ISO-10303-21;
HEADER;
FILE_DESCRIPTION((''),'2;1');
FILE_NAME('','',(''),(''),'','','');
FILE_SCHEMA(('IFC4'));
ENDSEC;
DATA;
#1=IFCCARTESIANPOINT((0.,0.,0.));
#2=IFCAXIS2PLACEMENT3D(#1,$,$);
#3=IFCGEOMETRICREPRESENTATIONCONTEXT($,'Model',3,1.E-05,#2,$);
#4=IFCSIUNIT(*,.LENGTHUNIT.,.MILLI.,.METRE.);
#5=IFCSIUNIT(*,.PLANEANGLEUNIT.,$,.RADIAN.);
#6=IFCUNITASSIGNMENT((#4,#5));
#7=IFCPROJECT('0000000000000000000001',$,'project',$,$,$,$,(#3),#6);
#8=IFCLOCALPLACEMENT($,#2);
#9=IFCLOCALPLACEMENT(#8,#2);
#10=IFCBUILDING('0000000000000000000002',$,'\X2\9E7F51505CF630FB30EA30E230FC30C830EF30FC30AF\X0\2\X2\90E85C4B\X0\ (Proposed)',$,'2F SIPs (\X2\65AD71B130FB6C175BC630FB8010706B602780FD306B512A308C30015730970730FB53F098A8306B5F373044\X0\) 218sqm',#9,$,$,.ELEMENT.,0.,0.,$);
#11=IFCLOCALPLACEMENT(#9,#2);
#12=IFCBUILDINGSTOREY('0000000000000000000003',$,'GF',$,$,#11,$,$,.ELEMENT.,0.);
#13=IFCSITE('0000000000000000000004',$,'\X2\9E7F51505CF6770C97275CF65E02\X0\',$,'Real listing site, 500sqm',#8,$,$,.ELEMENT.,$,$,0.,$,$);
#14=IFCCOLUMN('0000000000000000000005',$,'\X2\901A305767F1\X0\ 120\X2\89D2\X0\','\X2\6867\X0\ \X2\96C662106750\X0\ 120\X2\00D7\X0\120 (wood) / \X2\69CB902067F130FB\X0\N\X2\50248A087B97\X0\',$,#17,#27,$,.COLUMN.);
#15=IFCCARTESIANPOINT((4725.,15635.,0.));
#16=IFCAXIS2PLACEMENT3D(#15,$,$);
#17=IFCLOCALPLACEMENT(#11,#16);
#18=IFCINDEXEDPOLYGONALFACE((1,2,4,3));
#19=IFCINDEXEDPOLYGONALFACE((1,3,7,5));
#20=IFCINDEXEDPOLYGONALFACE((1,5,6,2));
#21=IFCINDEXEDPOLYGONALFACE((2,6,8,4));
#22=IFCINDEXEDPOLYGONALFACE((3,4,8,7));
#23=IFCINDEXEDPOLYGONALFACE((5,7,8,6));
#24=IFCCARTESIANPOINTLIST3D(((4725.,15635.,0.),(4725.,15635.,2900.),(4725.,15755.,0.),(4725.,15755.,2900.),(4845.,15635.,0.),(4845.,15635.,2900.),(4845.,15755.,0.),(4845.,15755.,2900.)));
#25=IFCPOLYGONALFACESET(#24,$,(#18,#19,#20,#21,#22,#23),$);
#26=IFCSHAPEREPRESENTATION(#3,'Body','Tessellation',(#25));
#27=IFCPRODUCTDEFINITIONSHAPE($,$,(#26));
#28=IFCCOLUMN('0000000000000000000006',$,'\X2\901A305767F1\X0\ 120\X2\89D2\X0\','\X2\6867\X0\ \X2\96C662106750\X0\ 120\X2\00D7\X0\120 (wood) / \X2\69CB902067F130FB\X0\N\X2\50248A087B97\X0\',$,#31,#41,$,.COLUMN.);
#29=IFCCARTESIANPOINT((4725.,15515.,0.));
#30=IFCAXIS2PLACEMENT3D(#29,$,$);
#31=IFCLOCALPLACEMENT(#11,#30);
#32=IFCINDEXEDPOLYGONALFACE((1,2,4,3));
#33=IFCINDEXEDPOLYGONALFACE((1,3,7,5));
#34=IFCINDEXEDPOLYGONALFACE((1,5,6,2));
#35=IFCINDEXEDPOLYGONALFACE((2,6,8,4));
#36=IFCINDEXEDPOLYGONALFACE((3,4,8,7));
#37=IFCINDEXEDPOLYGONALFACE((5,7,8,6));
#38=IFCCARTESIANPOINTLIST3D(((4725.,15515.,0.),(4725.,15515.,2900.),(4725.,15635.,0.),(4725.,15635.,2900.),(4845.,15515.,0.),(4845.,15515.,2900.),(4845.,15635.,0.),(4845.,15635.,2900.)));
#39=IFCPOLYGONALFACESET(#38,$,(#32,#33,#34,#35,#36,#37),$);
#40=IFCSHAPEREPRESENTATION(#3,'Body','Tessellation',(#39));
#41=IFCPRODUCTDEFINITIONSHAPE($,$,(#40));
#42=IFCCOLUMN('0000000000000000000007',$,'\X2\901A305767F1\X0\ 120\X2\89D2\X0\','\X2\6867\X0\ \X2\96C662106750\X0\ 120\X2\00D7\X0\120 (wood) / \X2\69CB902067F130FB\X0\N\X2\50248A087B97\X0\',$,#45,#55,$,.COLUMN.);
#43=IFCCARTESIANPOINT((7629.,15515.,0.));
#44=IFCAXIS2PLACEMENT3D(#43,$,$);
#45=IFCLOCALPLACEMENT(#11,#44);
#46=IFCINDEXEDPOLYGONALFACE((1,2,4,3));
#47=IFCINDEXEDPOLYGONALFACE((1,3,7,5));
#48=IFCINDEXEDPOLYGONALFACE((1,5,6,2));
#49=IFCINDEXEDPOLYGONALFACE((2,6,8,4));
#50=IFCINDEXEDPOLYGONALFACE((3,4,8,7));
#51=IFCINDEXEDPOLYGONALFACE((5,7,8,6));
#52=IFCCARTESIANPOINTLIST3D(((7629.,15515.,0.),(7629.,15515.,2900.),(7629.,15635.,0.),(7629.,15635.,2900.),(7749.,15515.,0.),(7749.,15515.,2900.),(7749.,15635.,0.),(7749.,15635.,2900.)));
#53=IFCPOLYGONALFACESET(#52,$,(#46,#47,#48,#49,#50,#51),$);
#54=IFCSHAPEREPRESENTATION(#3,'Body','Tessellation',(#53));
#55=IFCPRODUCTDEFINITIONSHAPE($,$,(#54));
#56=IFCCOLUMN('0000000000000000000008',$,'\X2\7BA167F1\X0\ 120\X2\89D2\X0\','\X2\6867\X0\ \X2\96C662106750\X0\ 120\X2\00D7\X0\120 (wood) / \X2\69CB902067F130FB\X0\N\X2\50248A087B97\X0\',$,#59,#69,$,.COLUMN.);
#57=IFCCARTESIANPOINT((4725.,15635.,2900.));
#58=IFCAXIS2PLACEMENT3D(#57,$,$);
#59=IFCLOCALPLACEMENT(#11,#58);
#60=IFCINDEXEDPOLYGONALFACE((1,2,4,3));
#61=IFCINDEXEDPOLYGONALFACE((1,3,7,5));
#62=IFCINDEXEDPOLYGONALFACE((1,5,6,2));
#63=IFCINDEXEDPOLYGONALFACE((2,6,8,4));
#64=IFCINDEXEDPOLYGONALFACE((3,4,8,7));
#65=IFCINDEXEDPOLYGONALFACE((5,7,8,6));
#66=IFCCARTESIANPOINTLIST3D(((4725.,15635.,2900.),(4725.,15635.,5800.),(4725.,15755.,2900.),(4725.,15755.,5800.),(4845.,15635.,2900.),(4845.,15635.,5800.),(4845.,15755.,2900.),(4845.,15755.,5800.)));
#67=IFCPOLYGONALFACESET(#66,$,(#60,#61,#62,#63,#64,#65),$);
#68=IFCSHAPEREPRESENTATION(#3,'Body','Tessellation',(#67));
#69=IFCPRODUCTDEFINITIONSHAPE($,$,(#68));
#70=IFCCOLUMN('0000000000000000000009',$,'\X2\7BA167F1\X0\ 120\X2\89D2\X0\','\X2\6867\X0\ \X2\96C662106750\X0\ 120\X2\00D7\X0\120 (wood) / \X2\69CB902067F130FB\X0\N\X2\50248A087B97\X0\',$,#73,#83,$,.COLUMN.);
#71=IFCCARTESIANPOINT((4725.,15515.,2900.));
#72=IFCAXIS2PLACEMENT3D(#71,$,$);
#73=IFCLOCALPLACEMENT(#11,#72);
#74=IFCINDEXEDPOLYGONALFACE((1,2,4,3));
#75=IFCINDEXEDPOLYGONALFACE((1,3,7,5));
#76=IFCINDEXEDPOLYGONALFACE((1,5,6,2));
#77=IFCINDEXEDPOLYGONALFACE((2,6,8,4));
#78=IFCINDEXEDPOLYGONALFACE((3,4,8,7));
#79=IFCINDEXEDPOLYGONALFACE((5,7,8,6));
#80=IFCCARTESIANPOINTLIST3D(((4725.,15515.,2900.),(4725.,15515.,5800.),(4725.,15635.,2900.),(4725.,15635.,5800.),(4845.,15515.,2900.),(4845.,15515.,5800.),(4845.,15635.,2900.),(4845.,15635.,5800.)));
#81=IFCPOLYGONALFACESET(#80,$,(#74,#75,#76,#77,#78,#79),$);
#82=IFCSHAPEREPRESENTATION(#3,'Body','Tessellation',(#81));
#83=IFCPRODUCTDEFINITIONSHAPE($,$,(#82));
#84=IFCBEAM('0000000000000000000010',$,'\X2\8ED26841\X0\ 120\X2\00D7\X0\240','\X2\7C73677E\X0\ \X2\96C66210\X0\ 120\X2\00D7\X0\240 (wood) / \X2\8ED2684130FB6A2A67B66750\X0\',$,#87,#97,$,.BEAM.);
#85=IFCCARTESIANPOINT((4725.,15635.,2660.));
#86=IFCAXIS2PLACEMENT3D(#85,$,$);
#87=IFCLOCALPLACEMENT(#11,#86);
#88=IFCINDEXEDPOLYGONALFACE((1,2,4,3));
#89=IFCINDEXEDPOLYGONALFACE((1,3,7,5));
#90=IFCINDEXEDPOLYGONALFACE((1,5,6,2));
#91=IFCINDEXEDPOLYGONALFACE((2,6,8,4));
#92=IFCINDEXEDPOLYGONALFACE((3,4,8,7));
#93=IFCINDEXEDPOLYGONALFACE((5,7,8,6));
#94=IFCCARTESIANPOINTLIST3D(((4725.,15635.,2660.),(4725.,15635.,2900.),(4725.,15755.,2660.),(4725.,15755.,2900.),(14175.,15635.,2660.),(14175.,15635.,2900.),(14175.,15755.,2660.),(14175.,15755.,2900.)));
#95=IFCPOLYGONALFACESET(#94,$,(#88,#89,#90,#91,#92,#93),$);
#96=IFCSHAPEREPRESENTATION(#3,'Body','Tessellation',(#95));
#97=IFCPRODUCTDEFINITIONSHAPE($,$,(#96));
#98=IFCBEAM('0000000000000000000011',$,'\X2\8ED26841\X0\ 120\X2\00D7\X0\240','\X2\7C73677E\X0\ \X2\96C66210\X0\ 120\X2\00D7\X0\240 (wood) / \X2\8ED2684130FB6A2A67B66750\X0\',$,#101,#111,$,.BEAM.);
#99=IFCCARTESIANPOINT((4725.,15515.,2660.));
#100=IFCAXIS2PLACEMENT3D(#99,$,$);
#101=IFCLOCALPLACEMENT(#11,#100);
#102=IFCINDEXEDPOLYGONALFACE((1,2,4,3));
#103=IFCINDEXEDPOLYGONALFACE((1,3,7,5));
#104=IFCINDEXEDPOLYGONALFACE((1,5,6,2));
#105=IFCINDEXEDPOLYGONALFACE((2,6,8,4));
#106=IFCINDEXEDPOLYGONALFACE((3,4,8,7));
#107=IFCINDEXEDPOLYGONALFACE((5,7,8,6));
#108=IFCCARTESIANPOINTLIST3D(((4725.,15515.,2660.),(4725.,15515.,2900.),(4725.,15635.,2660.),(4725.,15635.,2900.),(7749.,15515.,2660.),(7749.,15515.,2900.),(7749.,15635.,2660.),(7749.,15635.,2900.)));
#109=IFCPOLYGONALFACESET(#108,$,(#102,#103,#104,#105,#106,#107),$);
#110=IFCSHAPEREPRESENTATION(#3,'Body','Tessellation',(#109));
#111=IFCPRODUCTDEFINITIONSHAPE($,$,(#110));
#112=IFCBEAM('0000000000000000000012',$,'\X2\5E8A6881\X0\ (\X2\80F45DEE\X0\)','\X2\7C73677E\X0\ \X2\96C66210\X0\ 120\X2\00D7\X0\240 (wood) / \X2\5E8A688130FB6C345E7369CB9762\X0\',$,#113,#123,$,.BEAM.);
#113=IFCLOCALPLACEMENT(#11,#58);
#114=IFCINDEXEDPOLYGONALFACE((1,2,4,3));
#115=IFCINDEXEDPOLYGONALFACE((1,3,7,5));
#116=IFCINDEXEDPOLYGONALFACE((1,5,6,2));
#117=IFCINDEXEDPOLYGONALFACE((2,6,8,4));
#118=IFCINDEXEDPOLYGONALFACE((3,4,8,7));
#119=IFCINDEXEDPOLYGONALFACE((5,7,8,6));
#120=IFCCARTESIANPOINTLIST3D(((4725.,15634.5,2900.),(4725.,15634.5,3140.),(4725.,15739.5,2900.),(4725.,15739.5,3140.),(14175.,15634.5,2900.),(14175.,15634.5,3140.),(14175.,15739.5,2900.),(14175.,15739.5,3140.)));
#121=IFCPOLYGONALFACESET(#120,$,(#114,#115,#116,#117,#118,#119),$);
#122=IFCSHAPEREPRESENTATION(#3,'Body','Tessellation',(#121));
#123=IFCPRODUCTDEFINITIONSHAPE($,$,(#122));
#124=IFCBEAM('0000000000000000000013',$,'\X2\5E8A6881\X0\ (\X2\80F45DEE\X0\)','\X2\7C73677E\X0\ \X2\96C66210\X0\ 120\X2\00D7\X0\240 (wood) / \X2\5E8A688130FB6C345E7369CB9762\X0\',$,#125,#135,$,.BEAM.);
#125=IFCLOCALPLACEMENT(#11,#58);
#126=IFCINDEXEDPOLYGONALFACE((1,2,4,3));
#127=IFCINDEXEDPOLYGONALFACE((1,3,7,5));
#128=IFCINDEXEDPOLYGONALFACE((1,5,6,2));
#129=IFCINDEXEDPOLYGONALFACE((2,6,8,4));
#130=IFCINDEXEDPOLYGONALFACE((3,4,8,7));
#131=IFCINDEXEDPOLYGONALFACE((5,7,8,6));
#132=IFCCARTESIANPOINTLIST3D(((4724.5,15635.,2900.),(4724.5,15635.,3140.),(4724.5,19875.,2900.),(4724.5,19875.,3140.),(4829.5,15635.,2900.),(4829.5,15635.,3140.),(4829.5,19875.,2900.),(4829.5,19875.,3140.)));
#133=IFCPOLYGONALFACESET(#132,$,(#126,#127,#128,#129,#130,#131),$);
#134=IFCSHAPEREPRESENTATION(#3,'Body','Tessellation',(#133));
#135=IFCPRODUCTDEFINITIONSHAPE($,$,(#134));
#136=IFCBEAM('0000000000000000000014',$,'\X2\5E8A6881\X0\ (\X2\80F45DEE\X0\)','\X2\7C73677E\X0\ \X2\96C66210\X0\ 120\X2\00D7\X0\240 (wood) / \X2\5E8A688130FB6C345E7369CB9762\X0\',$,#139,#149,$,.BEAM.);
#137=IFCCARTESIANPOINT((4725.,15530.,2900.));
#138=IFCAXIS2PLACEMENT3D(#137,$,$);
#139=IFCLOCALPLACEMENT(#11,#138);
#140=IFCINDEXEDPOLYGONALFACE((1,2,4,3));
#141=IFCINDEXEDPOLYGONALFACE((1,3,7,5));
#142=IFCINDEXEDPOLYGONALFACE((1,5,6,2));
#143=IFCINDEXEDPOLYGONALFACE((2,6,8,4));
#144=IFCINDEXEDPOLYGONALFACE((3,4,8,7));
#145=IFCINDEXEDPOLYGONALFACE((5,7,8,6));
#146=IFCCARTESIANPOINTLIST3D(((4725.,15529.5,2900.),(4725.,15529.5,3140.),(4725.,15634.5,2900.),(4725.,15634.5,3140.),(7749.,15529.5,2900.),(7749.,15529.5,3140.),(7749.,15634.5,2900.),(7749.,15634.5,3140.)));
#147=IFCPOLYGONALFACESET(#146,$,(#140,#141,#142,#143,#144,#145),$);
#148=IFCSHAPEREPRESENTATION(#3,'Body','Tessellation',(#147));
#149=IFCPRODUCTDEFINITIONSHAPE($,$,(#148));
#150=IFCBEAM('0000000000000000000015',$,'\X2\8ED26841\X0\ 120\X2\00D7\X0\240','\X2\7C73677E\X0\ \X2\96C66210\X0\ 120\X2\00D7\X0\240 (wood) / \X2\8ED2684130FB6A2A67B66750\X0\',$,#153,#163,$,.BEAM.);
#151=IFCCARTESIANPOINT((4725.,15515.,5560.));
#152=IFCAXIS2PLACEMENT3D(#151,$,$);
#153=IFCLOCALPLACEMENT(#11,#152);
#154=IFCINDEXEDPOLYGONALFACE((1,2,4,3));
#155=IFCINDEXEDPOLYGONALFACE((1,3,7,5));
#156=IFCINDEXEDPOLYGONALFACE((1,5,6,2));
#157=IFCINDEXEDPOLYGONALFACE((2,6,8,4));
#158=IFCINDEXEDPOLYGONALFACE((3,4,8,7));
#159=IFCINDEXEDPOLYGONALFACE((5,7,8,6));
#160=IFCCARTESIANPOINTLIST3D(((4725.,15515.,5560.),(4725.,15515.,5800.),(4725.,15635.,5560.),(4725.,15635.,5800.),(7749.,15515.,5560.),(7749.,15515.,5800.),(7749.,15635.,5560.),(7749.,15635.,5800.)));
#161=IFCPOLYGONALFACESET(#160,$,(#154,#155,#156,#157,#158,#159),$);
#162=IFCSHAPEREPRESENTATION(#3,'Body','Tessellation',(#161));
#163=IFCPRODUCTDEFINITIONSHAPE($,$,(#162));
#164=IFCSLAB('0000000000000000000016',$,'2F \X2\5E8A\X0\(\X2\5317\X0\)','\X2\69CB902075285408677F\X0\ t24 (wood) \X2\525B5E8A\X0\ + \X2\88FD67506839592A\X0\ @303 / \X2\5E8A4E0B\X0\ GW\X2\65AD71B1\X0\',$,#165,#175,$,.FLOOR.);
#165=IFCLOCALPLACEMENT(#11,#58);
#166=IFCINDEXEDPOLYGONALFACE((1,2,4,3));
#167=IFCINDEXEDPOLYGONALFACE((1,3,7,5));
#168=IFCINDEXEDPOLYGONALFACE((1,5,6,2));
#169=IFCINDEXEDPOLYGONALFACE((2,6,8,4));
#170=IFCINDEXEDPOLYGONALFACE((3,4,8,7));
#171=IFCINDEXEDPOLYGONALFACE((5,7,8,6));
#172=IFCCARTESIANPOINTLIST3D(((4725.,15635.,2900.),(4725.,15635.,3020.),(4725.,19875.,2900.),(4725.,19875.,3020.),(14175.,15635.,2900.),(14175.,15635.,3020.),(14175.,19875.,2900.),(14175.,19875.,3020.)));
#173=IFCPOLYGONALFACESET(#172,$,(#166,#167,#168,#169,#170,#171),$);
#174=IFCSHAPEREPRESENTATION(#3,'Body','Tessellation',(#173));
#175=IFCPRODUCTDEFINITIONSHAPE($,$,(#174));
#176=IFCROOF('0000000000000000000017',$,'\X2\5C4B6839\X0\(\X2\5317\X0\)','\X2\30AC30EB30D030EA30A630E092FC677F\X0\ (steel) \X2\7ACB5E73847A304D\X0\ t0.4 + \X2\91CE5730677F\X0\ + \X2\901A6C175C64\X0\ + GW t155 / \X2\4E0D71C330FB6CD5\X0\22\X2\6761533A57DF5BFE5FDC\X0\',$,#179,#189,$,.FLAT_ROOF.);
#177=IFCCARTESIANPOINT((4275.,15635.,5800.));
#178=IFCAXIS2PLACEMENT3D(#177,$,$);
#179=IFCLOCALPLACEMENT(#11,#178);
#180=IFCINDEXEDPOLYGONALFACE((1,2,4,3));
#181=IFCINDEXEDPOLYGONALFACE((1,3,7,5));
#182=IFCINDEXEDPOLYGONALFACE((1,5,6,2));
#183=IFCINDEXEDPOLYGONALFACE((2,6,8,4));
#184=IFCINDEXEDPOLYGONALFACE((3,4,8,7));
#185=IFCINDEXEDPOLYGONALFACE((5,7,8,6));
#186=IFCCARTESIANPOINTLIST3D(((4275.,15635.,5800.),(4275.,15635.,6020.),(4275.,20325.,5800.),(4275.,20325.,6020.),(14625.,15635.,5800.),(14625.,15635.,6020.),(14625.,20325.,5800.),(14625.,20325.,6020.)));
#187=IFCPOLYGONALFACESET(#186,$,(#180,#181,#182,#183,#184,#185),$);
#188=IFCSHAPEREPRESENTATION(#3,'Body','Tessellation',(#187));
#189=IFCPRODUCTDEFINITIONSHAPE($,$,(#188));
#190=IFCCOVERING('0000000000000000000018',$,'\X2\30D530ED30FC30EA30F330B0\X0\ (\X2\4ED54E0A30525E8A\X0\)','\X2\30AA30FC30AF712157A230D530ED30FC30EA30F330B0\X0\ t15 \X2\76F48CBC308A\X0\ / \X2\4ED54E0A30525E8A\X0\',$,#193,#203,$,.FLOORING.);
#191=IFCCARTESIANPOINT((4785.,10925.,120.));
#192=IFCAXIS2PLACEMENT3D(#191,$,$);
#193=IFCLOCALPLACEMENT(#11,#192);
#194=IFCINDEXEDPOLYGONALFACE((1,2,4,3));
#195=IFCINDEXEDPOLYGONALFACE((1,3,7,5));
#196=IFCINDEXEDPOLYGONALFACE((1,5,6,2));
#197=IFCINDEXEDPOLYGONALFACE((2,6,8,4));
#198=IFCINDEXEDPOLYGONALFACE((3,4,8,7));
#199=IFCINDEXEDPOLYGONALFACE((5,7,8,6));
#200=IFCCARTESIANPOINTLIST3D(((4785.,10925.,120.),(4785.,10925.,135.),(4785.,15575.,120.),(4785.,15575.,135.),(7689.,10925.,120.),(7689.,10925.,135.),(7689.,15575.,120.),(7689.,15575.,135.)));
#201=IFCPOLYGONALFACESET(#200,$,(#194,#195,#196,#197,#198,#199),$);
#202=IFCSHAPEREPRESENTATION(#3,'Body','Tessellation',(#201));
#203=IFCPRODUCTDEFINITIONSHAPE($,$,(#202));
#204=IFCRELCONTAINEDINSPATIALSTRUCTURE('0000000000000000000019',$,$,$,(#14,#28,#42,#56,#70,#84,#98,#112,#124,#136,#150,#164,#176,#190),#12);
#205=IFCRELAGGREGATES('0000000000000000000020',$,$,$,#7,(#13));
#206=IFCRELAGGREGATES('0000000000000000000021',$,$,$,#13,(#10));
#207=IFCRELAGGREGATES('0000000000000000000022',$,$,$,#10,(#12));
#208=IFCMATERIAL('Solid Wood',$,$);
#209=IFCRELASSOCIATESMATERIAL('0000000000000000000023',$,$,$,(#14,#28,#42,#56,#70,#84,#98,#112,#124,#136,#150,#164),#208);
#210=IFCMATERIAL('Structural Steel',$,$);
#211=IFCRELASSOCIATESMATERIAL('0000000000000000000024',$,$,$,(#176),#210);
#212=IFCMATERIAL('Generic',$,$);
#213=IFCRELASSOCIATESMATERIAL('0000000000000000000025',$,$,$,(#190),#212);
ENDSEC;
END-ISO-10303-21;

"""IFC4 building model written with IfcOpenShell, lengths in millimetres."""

from ifc_helpers import new_model, si_unit, frame, frame_2d, origin, place, context, project, spatial, rectangle, extrude, material, element, save


model = new_model("IFC4")

# Units and contexts
model_context = context("Model", 3, precision=1e-05, world=origin())
ifc_project = project(units=[si_unit("LENGTHUNIT", "METRE", prefix="MILLI"), si_unit("PLANEANGLEUNIT", "RADIAN")], contexts=[model_context])

# Site, building, storey
site_placement = place(None, origin())
site = spatial("IfcSite", under=ifc_project, at=site_placement, Name="鹿児島県霧島市", ObjectType="Real listing site, 500sqm", CompositionType="ELEMENT", RefElevation=0.0)
building_placement = place(site_placement, origin())
building = spatial("IfcBuilding", under=site, at=building_placement, Name="鹿児島・リモートワーク2部屋 (Proposed)", ObjectType="2F SIPs (断熱・気密・耐火性能に優れ、地震・台風に強い) 218sqm", CompositionType="ELEMENT", ElevationOfRefHeight=0.0, ElevationOfTerrain=0.0)
storey_placement = place(building_placement, origin())
storey = spatial("IfcBuildingStorey", under=building, at=storey_placement, Name="GF", CompositionType="ELEMENT", Elevation=0.0)

# Columns
ifc_material_1 = material(Name="Solid Wood")
column_1_placement = place(storey_placement, frame((4725.0, 15635.0, 0.0)))
element("IfcColumn", 1, at=column_1_placement, inside=storey, material=ifc_material_1, Name="通し柱 120角", Description="桧 集成材 120×120 (wood) / 構造柱・N値計算", PredefinedType="COLUMN", context=model_context, shape_type="SweptSolid", body=[
    extrude(rectangle(XDim=120.0, YDim=120.0, at=frame_2d((60.0, 60.0))), frame((4725.0, 15635.0, 0.0)), (0.0, 0.0, 1.0), 2900.0),
])
column_2_placement = place(storey_placement, frame((4725.0, 15515.0, 0.0)))
element("IfcColumn", 2, at=column_2_placement, inside=storey, material=ifc_material_1, Name="通し柱 120角", Description="桧 集成材 120×120 (wood) / 構造柱・N値計算", PredefinedType="COLUMN", context=model_context, shape_type="SweptSolid", body=[
    extrude(rectangle(XDim=120.0, YDim=120.0, at=frame_2d((60.0, 60.0))), frame((4725.0, 15515.0, 0.0)), (0.0, 0.0, 1.0), 2900.0),
])
column_3_placement = place(storey_placement, frame((7629.0, 15515.0, 0.0)))
element("IfcColumn", 3, at=column_3_placement, inside=storey, material=ifc_material_1, Name="通し柱 120角", Description="桧 集成材 120×120 (wood) / 構造柱・N値計算", PredefinedType="COLUMN", context=model_context, shape_type="SweptSolid", body=[
    extrude(rectangle(XDim=120.0, YDim=120.0, at=frame_2d((60.0, 60.0))), frame((7629.0, 15515.0, 0.0)), (0.0, 0.0, 1.0), 2900.0),
])
column_4_placement = place(storey_placement, frame((4725.0, 15635.0, 2900.0)))
element("IfcColumn", 4, at=column_4_placement, inside=storey, material=ifc_material_1, Name="管柱 120角", Description="桧 集成材 120×120 (wood) / 構造柱・N値計算", PredefinedType="COLUMN", context=model_context, shape_type="SweptSolid", body=[
    extrude(rectangle(XDim=120.0, YDim=120.0, at=frame_2d((60.0, 60.0))), frame((4725.0, 15635.0, 2900.0)), (0.0, 0.0, 1.0), 2900.0),
])
column_5_placement = place(storey_placement, frame((4725.0, 15515.0, 2900.0)))
element("IfcColumn", 5, at=column_5_placement, inside=storey, material=ifc_material_1, Name="管柱 120角", Description="桧 集成材 120×120 (wood) / 構造柱・N値計算", PredefinedType="COLUMN", context=model_context, shape_type="SweptSolid", body=[
    extrude(rectangle(XDim=120.0, YDim=120.0, at=frame_2d((60.0, 60.0))), frame((4725.0, 15515.0, 2900.0)), (0.0, 0.0, 1.0), 2900.0),
])

# Beams
beam_1_placement = place(storey_placement, frame((4725.0, 15635.0, 2660.0)))
element("IfcBeam", 6, at=beam_1_placement, inside=storey, material=ifc_material_1, Name="軒桁 120×240", Description="米松 集成 120×240 (wood) / 軒桁・横架材", PredefinedType="BEAM", context=model_context, shape_type="SweptSolid", body=[
    extrude(rectangle(XDim=9450.0, YDim=120.0, at=frame_2d((4725.0, 60.0))), frame((4725.0, 15635.0, 2660.0)), (0.0, 0.0, 1.0), 240.0),
])
beam_2_placement = place(storey_placement, frame((4725.0, 15515.0, 2660.0)))
element("IfcBeam", 7, at=beam_2_placement, inside=storey, material=ifc_material_1, Name="軒桁 120×240", Description="米松 集成 120×240 (wood) / 軒桁・横架材", PredefinedType="BEAM", context=model_context, shape_type="SweptSolid", body=[
    extrude(rectangle(XDim=3024.0, YDim=120.0, at=frame_2d((1512.0, 60.0))), frame((4725.0, 15515.0, 2660.0)), (0.0, 0.0, 1.0), 240.0),
])
beam_3_placement = place(storey_placement, frame((4725.0, 15635.0, 2900.0)))
element("IfcBeam", 8, at=beam_3_placement, inside=storey, material=ifc_material_1, Name="床梁 (胴差)", Description="米松 集成 120×240 (wood) / 床梁・水平構面", PredefinedType="BEAM", context=model_context, shape_type="SweptSolid", body=[
    extrude(rectangle(XDim=9450.0, YDim=105.0, at=frame_2d((4725.0, 52.0))), frame((4725.0, 15635.0, 2900.0)), (0.0, 0.0, 1.0), 240.0),
])
beam_4_placement = place(storey_placement, frame((4725.0, 15635.0, 2900.0)))
element("IfcBeam", 9, at=beam_4_placement, inside=storey, material=ifc_material_1, Name="床梁 (胴差)", Description="米松 集成 120×240 (wood) / 床梁・水平構面", PredefinedType="BEAM", context=model_context, shape_type="SweptSolid", body=[
    extrude(rectangle(XDim=105.0, YDim=4240.0, at=frame_2d((52.0, 2120.0))), frame((4725.0, 15635.0, 2900.0)), (0.0, 0.0, 1.0), 240.0),
])
beam_5_placement = place(storey_placement, frame((4725.0, 15530.0, 2900.0)))
element("IfcBeam", 10, at=beam_5_placement, inside=storey, material=ifc_material_1, Name="床梁 (胴差)", Description="米松 集成 120×240 (wood) / 床梁・水平構面", PredefinedType="BEAM", context=model_context, shape_type="SweptSolid", body=[
    extrude(rectangle(XDim=3024.0, YDim=105.0, at=frame_2d((1512.0, 52.0))), frame((4725.0, 15530.0, 2900.0)), (0.0, 0.0, 1.0), 240.0),
])
beam_6_placement = place(storey_placement, frame((4725.0, 15515.0, 5560.0)))
element("IfcBeam", 11, at=beam_6_placement, inside=storey, material=ifc_material_1, Name="軒桁 120×240", Description="米松 集成 120×240 (wood) / 軒桁・横架材", PredefinedType="BEAM", context=model_context, shape_type="SweptSolid", body=[
    extrude(rectangle(XDim=3024.0, YDim=120.0, at=frame_2d((1512.0, 60.0))), frame((4725.0, 15515.0, 5560.0)), (0.0, 0.0, 1.0), 240.0),
])

# Slab
slab_1_placement = place(storey_placement, frame((4725.0, 15635.0, 2900.0)))
element("IfcSlab", 12, at=slab_1_placement, inside=storey, material=ifc_material_1, Name="2F 床(北)", Description="構造用合板 t24 (wood) 剛床 + 製材根太 @303 / 床下 GW断熱", PredefinedType="FLOOR", context=model_context, shape_type="SweptSolid", body=[
    extrude(rectangle(XDim=9450.0, YDim=4240.0, at=frame_2d((4725.0, 2120.0))), frame((4725.0, 15635.0, 2900.0)), (0.0, 0.0, 1.0), 120.0),
])

# Roof
ifc_material_2 = material(Name="Structural Steel")
for number, where, name in (
    (13, (4275.0, 15635.0, 5800.0), "屋根(北)"),
):
    element("IfcRoof", number, at=place(storey_placement, frame(where)), inside=storey, material=ifc_material_2, Name=name, Description="ガルバリウム鋼板 (steel) 立平葺き t0.4 + 野地板 + 通気層 + GW t155 / 不燃・法22条区域対応", PredefinedType="FLAT_ROOF", context=model_context, shape_type="SweptSolid", body=[
        extrude(rectangle(XDim=10350.0, YDim=4690.0, at=frame_2d((5175.0, 2345.0))), frame((4275.0, 15635.0, 5800.0)), (0.0, 0.0, 1.0), 220.0),
    ])

# Covering
ifc_material_3 = material(Name="Generic")
covering_1_placement = place(storey_placement, frame((4785.0, 10925.0, 120.0)))
element("IfcCovering", 14, at=covering_1_placement, inside=storey, material=ifc_material_3, Name="フローリング (仕上げ床)", Description="オーク無垢フローリング t15 直貼り / 仕上げ床", PredefinedType="FLOORING", context=model_context, shape_type="SweptSolid", body=[
    extrude(rectangle(XDim=2904.0, YDim=4650.0, at=frame_2d((1452.0, 2325.0))), frame((4785.0, 10925.0, 120.0)), (0.0, 0.0, 1.0), 15.0),
])

save(model, "model.ifc")
